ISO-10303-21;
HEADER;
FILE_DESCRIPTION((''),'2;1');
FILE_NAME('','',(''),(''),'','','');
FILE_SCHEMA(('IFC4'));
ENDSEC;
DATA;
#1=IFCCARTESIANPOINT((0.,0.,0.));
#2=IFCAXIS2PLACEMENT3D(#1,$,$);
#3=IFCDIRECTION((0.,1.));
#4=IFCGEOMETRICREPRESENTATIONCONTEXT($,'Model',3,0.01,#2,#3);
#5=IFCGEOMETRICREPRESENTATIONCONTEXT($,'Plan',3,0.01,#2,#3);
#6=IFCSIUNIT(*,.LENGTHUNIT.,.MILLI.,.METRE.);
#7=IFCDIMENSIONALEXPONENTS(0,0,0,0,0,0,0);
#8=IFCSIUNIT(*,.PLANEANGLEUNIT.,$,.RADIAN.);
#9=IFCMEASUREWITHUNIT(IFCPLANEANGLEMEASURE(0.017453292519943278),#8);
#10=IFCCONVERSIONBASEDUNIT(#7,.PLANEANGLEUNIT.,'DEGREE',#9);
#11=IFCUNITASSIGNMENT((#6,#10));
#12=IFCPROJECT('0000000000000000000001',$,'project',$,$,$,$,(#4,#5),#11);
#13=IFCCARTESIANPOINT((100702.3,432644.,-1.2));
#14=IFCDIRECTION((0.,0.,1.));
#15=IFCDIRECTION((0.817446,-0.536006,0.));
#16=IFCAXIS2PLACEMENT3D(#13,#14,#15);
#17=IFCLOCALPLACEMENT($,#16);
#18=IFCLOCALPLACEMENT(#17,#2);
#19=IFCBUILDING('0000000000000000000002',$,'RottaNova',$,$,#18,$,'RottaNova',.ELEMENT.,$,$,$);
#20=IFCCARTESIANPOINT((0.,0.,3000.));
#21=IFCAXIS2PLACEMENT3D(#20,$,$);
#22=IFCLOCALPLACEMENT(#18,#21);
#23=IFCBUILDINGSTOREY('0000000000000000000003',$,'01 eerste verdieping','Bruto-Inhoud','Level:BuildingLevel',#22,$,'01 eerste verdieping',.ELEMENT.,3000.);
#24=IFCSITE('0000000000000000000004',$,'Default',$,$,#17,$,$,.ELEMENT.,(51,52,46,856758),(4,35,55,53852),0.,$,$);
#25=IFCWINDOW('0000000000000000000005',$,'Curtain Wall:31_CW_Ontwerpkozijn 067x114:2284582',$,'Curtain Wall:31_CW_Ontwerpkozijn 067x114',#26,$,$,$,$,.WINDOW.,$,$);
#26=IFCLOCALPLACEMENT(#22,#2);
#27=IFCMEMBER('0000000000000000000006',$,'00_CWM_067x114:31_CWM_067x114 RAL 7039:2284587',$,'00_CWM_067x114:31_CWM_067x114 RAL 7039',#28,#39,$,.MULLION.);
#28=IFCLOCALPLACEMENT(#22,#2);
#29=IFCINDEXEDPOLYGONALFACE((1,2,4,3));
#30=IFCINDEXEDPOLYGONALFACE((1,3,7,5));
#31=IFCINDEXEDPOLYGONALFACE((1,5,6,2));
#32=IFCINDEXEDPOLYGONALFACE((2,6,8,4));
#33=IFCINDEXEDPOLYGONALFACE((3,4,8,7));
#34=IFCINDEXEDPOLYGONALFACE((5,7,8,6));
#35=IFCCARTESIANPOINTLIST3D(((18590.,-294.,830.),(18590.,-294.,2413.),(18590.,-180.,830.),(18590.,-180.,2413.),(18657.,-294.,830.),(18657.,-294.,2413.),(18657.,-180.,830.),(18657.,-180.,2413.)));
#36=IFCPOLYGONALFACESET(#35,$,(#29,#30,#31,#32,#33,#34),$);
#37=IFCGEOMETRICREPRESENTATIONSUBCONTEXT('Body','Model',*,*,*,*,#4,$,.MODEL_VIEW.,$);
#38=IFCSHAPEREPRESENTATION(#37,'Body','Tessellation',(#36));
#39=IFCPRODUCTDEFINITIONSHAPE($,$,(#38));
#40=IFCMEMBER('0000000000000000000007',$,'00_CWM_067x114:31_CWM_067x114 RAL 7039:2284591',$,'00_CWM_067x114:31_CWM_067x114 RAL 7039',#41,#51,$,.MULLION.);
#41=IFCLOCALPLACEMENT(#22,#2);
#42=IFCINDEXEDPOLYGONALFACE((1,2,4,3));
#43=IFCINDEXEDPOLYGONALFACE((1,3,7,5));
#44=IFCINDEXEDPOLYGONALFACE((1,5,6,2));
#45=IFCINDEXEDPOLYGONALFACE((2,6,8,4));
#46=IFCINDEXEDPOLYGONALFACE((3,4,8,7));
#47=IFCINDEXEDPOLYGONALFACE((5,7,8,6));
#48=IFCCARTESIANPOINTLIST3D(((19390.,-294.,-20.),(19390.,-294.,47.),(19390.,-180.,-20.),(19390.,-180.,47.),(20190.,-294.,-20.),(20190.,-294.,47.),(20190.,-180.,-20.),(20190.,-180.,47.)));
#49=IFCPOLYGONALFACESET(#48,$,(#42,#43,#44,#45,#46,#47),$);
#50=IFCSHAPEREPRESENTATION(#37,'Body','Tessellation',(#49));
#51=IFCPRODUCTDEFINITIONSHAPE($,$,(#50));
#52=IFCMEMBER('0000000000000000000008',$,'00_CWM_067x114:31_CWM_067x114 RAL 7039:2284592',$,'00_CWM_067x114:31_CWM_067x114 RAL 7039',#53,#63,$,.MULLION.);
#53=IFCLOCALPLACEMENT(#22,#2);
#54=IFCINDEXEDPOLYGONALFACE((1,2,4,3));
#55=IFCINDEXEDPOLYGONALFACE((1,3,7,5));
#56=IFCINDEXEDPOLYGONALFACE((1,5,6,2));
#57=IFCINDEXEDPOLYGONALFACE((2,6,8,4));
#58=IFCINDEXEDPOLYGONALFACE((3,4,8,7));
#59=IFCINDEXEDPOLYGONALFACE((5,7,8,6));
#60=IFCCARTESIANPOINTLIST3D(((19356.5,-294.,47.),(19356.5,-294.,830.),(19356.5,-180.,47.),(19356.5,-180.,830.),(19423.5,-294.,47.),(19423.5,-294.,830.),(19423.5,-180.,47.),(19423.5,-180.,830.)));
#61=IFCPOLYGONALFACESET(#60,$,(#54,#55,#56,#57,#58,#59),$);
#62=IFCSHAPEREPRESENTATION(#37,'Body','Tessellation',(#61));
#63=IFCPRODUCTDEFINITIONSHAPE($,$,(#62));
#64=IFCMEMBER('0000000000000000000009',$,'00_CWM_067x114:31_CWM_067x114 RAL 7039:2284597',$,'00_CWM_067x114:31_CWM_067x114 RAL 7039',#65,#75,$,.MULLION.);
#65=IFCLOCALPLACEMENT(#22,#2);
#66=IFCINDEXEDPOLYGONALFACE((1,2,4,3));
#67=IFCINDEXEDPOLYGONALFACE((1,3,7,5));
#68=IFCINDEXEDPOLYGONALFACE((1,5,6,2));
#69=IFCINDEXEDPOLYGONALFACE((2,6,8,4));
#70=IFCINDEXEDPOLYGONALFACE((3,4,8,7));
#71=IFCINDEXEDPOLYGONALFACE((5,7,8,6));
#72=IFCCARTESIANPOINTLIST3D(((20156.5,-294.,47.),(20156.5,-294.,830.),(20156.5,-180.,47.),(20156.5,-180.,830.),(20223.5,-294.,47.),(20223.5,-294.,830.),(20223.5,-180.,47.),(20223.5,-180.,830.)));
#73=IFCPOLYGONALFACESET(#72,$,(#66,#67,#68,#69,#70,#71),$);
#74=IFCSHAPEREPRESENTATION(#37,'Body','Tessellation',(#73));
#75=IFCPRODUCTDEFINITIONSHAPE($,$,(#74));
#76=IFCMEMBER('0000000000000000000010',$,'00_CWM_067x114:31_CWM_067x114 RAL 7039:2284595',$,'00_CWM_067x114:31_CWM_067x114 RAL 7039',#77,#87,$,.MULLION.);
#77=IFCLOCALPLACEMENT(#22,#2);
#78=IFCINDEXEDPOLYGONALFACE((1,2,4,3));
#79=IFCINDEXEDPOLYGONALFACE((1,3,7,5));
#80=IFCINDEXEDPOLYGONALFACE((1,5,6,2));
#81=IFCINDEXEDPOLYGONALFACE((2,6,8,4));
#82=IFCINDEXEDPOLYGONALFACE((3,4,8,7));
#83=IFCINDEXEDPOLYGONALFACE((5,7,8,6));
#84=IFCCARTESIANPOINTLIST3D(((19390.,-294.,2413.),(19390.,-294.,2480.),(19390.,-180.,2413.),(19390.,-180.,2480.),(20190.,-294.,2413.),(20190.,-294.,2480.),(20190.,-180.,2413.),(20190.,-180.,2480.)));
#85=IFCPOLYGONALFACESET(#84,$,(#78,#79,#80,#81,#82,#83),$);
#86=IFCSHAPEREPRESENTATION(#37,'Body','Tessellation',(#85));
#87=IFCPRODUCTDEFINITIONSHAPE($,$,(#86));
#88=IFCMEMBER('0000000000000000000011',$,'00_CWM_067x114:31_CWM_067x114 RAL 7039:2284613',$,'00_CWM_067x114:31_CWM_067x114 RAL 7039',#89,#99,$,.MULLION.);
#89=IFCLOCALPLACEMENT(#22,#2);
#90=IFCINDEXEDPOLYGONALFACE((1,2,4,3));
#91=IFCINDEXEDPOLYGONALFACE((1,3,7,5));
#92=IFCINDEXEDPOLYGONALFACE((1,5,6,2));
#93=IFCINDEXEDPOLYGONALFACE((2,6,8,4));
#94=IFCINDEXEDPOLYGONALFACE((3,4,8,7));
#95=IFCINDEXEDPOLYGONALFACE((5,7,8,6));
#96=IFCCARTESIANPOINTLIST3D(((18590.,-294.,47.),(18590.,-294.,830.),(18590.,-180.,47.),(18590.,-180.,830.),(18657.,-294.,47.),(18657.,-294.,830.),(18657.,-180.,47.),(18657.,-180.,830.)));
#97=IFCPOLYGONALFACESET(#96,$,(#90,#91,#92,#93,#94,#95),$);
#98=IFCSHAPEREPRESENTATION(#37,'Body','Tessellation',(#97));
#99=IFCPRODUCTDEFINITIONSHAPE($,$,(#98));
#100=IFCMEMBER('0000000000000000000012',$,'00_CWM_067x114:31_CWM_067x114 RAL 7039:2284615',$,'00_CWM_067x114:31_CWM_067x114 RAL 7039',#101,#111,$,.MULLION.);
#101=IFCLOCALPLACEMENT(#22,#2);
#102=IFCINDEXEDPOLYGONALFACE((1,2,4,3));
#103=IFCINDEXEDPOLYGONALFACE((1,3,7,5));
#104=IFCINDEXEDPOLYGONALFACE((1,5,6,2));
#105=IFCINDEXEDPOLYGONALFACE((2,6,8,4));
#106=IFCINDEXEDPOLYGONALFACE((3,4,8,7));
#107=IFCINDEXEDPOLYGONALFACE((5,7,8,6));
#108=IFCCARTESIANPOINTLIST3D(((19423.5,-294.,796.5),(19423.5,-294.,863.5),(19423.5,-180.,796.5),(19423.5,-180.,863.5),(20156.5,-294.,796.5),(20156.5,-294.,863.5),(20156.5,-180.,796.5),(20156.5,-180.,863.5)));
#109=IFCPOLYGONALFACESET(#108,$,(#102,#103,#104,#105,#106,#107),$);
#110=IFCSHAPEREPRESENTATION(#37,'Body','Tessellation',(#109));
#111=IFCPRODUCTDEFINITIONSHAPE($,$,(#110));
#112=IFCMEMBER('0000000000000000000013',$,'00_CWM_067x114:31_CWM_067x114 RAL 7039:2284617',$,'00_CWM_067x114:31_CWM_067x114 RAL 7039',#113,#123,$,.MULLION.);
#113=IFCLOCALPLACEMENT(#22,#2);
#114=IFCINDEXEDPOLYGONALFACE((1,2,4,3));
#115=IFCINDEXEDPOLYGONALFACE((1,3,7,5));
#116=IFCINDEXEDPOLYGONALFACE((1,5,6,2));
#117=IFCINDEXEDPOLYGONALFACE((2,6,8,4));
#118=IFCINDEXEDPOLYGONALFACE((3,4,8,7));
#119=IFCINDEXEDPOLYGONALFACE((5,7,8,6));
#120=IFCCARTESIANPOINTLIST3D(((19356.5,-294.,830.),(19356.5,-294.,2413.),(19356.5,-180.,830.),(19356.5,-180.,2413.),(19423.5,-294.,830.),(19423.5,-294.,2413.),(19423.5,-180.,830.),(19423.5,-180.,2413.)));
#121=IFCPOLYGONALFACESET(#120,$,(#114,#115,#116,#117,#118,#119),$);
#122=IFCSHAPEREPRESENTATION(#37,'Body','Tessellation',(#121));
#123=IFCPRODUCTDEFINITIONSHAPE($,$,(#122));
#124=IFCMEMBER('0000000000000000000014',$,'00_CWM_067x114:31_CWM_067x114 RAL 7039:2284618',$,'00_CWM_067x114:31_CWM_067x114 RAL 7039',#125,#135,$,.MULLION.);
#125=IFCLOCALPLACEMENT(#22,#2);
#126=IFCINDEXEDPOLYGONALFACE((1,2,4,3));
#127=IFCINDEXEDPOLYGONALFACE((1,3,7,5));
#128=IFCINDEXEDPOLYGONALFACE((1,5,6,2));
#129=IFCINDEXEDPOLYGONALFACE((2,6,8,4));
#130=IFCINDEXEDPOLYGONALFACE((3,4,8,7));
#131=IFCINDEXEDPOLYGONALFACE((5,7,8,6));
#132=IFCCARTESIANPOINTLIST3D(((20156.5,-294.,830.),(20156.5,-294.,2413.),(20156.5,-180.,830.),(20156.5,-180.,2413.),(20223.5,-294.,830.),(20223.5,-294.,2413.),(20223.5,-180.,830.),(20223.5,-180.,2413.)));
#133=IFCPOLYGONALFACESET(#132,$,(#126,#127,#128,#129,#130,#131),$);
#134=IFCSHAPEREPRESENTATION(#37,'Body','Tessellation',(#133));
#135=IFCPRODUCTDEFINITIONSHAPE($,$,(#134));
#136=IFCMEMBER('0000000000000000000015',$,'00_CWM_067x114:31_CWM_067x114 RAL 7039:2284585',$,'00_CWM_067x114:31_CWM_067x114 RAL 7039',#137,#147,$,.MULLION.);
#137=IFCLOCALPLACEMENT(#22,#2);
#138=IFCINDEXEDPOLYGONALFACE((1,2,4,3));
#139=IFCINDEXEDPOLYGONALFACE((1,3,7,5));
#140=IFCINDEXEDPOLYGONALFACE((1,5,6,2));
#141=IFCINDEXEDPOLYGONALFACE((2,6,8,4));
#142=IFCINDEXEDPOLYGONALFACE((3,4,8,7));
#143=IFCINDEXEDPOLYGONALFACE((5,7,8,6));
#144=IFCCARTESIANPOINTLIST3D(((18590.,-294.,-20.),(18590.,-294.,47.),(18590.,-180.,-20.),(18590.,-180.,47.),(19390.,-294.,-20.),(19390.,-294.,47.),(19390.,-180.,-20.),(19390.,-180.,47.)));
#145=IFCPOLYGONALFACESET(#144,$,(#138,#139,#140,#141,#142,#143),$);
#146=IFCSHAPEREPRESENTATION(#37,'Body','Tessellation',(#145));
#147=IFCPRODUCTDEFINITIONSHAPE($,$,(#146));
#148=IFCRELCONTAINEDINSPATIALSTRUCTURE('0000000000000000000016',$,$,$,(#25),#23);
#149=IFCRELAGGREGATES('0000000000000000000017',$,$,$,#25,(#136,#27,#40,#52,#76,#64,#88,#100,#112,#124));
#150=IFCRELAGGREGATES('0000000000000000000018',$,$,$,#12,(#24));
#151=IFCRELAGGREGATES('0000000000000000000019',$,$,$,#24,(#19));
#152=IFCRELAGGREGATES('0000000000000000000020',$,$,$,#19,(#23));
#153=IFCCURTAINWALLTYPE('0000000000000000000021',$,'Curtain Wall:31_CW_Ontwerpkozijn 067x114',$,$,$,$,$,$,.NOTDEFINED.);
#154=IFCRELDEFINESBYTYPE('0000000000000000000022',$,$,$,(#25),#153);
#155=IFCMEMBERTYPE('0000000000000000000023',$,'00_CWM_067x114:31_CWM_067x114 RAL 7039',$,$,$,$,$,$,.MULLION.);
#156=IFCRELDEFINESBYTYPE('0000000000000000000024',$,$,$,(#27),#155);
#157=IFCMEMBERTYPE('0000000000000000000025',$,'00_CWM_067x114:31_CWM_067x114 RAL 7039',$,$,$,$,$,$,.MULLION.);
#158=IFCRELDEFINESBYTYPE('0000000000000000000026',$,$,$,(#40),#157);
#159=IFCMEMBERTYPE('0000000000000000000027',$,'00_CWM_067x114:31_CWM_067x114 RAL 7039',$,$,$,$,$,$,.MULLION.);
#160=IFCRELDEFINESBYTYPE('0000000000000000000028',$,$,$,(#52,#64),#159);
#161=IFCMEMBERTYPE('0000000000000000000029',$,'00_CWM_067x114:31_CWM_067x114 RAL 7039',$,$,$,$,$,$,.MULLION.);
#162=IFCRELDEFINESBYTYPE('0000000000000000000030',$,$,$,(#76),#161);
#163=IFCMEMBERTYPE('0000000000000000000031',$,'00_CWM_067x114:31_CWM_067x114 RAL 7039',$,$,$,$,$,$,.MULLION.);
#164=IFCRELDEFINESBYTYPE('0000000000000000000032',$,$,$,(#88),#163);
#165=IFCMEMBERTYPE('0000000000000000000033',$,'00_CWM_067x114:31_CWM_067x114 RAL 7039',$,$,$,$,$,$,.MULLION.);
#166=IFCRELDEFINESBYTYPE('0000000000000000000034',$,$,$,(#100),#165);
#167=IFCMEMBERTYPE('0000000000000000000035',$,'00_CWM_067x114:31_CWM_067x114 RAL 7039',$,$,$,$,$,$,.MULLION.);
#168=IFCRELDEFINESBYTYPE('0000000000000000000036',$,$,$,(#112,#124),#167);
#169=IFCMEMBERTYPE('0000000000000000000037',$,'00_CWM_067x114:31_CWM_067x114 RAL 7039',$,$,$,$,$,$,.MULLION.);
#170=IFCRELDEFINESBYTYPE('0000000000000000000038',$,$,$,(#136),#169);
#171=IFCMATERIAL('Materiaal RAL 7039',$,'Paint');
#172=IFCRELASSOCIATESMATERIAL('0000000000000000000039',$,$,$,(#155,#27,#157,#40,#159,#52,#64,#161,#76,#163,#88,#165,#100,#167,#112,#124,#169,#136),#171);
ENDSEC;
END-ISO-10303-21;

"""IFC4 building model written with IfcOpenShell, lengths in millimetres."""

from ifc_helpers import new_model, entity, si_unit, converted_unit, direction, frame, origin, place, context, subcontext, project, spatial, indexed_curve, outline, extrude, source, transform, mapped, material, type_object, type_shapes, element, aggregate, save


model = new_model("IFC4")

# Units and contexts
model_context = context("Model", 3, precision=0.01, world=origin(), true_north=direction((0.0, 1.0)))
plan_context = context("Plan", 3, precision=0.01, world=origin(), true_north=direction((0.0, 1.0)))
body_context = subcontext(model_context, "Body", "Model", "MODEL_VIEW")
ifc_project = project(units=[si_unit("LENGTHUNIT", "METRE", prefix="MILLI"), converted_unit("PLANEANGLEUNIT", "DEGREE", entity("IfcPlaneAngleMeasure", 0.017453292519943278), si_unit("PLANEANGLEUNIT", "RADIAN"), dimensions=[0, 0, 0, 0, 0, 0, 0])], contexts=[model_context, plan_context])

# Site, building, storey
site_placement = place(None, frame((100702.3, 432644.0, -1.2), z_axis=(0.0, 0.0, 1.0), x_axis=(0.817446, -0.536006, 0.0)))
site = spatial("IfcSite", under=ifc_project, at=site_placement, Name="Default", CompositionType="ELEMENT", RefLatitude=(51, 52, 46, 856758), RefLongitude=(4, 35, 55, 53852), RefElevation=0.0)
building_placement = place(site_placement, origin())
building = spatial("IfcBuilding", under=site, at=building_placement, Name="RottaNova", LongName="RottaNova", CompositionType="ELEMENT")
storey_placement = place(building_placement, frame((0.0, 0.0, 3000.0)))
storey = spatial("IfcBuildingStorey", under=building, at=storey_placement, Name="01 eerste verdieping", Description="Bruto-Inhoud", ObjectType="Level:BuildingLevel", LongName="01 eerste verdieping", CompositionType="ELEMENT", Elevation=3000.0)

# Window, members
curtain_wall_type = type_object("IfcCurtainWallType", Name="Curtain Wall:31_CW_Ontwerpkozijn 067x114", PredefinedType="NOTDEFINED")
window_1_placement = place(storey_placement, frame((0.0, 0.0, -3000.0)))
window_1 = element("IfcWindow", 1, at=window_1_placement, inside=storey, type_object=curtain_wall_type, Name="Curtain Wall:31_CW_Ontwerpkozijn 067x114:2284582", ObjectType="Curtain Wall:31_CW_Ontwerpkozijn 067x114", PredefinedType="WINDOW")
ifc_material_1 = material(Name="Materiaal RAL 7039", Category="Paint")
member_type_1 = type_object("IfcMemberType", Name="00_CWM_067x114:31_CWM_067x114 RAL 7039", PredefinedType="MULLION", material=ifc_material_1)
shared_shape_1 = source(origin(), body_context, "Body", "SweptSolid", [
    extrude(outline(indexed_curve([(-33.5, -57.0), (33.5, -57.0), (33.5, 57.0), (-33.5, 57.0), (-33.5, -57.0)], self_intersect=False)), frame((-33.5, 57.0, -1583.0), z_axis=(0.0, 0.0, 1.0), x_axis=(-1.0, 0.0, 0.0)), (0.0, 0.0, 1.0), 1583.0),
])
type_shapes(member_type_1, [shared_shape_1])
member_1_placement = place(window_1_placement, frame((18590.0, -180.0, 5413.0), z_axis=(0.0, 0.0, 1.0), x_axis=(-1.0, 0.0, 0.0)))
member_1 = element("IfcMember", 2, at=member_1_placement, type_object=member_type_1, material=ifc_material_1, Name="00_CWM_067x114:31_CWM_067x114 RAL 7039:2284587", ObjectType="00_CWM_067x114:31_CWM_067x114 RAL 7039", PredefinedType="MULLION", context=body_context, shape_type="MappedRepresentation", body=[
    mapped(shared_shape_1, transform((0.0, 0.0, 0.0), scale=1.0)),
])
member_type_2 = type_object("IfcMemberType", Name="00_CWM_067x114:31_CWM_067x114 RAL 7039", PredefinedType="MULLION", material=ifc_material_1)
shared_shape_2 = source(origin(), body_context, "Body", "SweptSolid", [
    extrude(outline(indexed_curve([(-33.5, -57.0), (33.5, -57.0), (33.5, 57.0), (-33.5, 57.0), (-33.5, -57.0)], self_intersect=False)), frame((-33.5, 57.0, -800.0), z_axis=(0.0, 0.0, 1.0), x_axis=(-1.0, 0.0, 0.0)), (0.0, 0.0, 1.0), 800.0),
])
type_shapes(member_type_2, [shared_shape_2])
member_2_placement = place(window_1_placement, frame((19390.0, -180.0, 2980.0), z_axis=(-1.0, 0.0, 0.0), x_axis=(0.0, 0.0, -1.0)))
member_2 = element("IfcMember", 3, at=member_2_placement, type_object=member_type_2, material=ifc_material_1, Name="00_CWM_067x114:31_CWM_067x114 RAL 7039:2284591", ObjectType="00_CWM_067x114:31_CWM_067x114 RAL 7039", PredefinedType="MULLION", context=body_context, shape_type="MappedRepresentation", body=[
    mapped(shared_shape_2, transform((0.0, 0.0, 0.0), scale=1.0)),
])
member_type_3 = type_object("IfcMemberType", Name="00_CWM_067x114:31_CWM_067x114 RAL 7039", PredefinedType="MULLION", material=ifc_material_1)
shared_shape_3 = source(origin(), body_context, "Body", "SweptSolid", [
    extrude(outline(indexed_curve([(-33.5, -57.0), (33.5, -57.0), (33.5, 57.0), (-33.5, 57.0), (-33.5, -57.0)], self_intersect=False)), frame((0.0, 57.0, -783.0), z_axis=(0.0, 0.0, 1.0), x_axis=(-1.0, 0.0, 0.0)), (0.0, 0.0, 1.0), 783.0),
])
type_shapes(member_type_3, [shared_shape_3])
member_3_placement = place(window_1_placement, frame((19390.0, -180.0, 3047.0), z_axis=(0.0, 0.0, -1.0), x_axis=(1.0, 0.0, 0.0)))
member_3 = element("IfcMember", 4, at=member_3_placement, type_object=member_type_3, material=ifc_material_1, Name="00_CWM_067x114:31_CWM_067x114 RAL 7039:2284592", ObjectType="00_CWM_067x114:31_CWM_067x114 RAL 7039", PredefinedType="MULLION", context=body_context, shape_type="MappedRepresentation", body=[
    mapped(shared_shape_3, transform((0.0, 0.0, 0.0), scale=1.0)),
])
member_4_placement = place(window_1_placement, frame((20190.0, -180.0, 3047.0), z_axis=(0.0, 0.0, -1.0), x_axis=(1.0, 0.0, 0.0)))
member_4 = element("IfcMember", 5, at=member_4_placement, type_object=member_type_3, material=ifc_material_1, Name="00_CWM_067x114:31_CWM_067x114 RAL 7039:2284597", ObjectType="00_CWM_067x114:31_CWM_067x114 RAL 7039", PredefinedType="MULLION", context=body_context, shape_type="MappedRepresentation", body=[
    mapped(shared_shape_3, transform((0.0, 0.0, 0.0), scale=1.0)),
])
member_type_4 = type_object("IfcMemberType", Name="00_CWM_067x114:31_CWM_067x114 RAL 7039", PredefinedType="MULLION", material=ifc_material_1)
shared_shape_4 = source(origin(), body_context, "Body", "SweptSolid", [
    extrude(outline(indexed_curve([(-33.5, -57.0), (33.5, -57.0), (33.5, 57.0), (-33.5, 57.0), (-33.5, -57.0)], self_intersect=False)), frame((-33.5, 57.0, -800.0), z_axis=(0.0, 0.0, 1.0), x_axis=(-1.0, 0.0, 0.0)), (0.0, 0.0, 1.0), 800.0),
])
type_shapes(member_type_4, [shared_shape_4])
member_5_placement = place(window_1_placement, frame((20190.0, -180.0, 5480.0), z_axis=(1.0, 0.0, 0.0), x_axis=(0.0, 0.0, 1.0)))
member_5 = element("IfcMember", 6, at=member_5_placement, type_object=member_type_4, material=ifc_material_1, Name="00_CWM_067x114:31_CWM_067x114 RAL 7039:2284595", ObjectType="00_CWM_067x114:31_CWM_067x114 RAL 7039", PredefinedType="MULLION", context=body_context, shape_type="MappedRepresentation", body=[
    mapped(shared_shape_4, transform((0.0, 0.0, 0.0), scale=1.0)),
])
member_type_5 = type_object("IfcMemberType", Name="00_CWM_067x114:31_CWM_067x114 RAL 7039", PredefinedType="MULLION", material=ifc_material_1)
shared_shape_5 = source(origin(), body_context, "Body", "SweptSolid", [
    extrude(outline(indexed_curve([(-33.5, -57.0), (33.5, -57.0), (33.5, 57.0), (-33.5, 57.0), (-33.5, -57.0)], self_intersect=False)), frame((-33.5, 57.0, -783.0), z_axis=(0.0, 0.0, 1.0), x_axis=(-1.0, 0.0, 0.0)), (0.0, 0.0, 1.0), 783.0),
])
type_shapes(member_type_5, [shared_shape_5])
member_6_placement = place(window_1_placement, frame((18590.0, -180.0, 3830.0), z_axis=(0.0, 0.0, 1.0), x_axis=(-1.0, 0.0, 0.0)))
member_6 = element("IfcMember", 7, at=member_6_placement, type_object=member_type_5, material=ifc_material_1, Name="00_CWM_067x114:31_CWM_067x114 RAL 7039:2284613", ObjectType="00_CWM_067x114:31_CWM_067x114 RAL 7039", PredefinedType="MULLION", context=body_context, shape_type="MappedRepresentation", body=[
    mapped(shared_shape_5, transform((0.0, 0.0, 0.0), scale=1.0)),
])
member_type_6 = type_object("IfcMemberType", Name="00_CWM_067x114:31_CWM_067x114 RAL 7039", PredefinedType="MULLION", material=ifc_material_1)
shared_shape_6 = source(origin(), body_context, "Body", "SweptSolid", [
    extrude(outline(indexed_curve([(-33.5, -57.0), (33.5, -57.0), (33.5, 57.0), (-33.5, 57.0), (-33.5, -57.0)], self_intersect=False)), frame((0.0, 57.0, -733.0), z_axis=(0.0, 0.0, 1.0), x_axis=(-1.0, 0.0, 0.0)), (0.0, 0.0, 1.0), 733.0),
])
type_shapes(member_type_6, [shared_shape_6])
member_7_placement = place(window_1_placement, frame((20156.5, -180.0, 3830.0), z_axis=(1.0, 0.0, 0.0), x_axis=(0.0, 0.0, 1.0)))
member_7 = element("IfcMember", 8, at=member_7_placement, type_object=member_type_6, material=ifc_material_1, Name="00_CWM_067x114:31_CWM_067x114 RAL 7039:2284615", ObjectType="00_CWM_067x114:31_CWM_067x114 RAL 7039", PredefinedType="MULLION", context=body_context, shape_type="MappedRepresentation", body=[
    mapped(shared_shape_6, transform((0.0, 0.0, 0.0), scale=1.0)),
])
member_type_7 = type_object("IfcMemberType", Name="00_CWM_067x114:31_CWM_067x114 RAL 7039", PredefinedType="MULLION", material=ifc_material_1)
shared_shape_7 = source(origin(), body_context, "Body", "SweptSolid", [
    extrude(outline(indexed_curve([(-33.5, -57.0), (33.5, -57.0), (33.5, 57.0), (-33.5, 57.0), (-33.5, -57.0)], self_intersect=False)), frame((0.0, 57.0, -1583.0), z_axis=(0.0, 0.0, 1.0), x_axis=(-1.0, 0.0, 0.0)), (0.0, 0.0, 1.0), 1583.0),
])
type_shapes(member_type_7, [shared_shape_7])
member_8_placement = place(window_1_placement, frame((19390.0, -180.0, 3830.0), z_axis=(0.0, 0.0, -1.0), x_axis=(1.0, 0.0, 0.0)))
member_8 = element("IfcMember", 9, at=member_8_placement, type_object=member_type_7, material=ifc_material_1, Name="00_CWM_067x114:31_CWM_067x114 RAL 7039:2284617", ObjectType="00_CWM_067x114:31_CWM_067x114 RAL 7039", PredefinedType="MULLION", context=body_context, shape_type="MappedRepresentation", body=[
    mapped(shared_shape_7, transform((0.0, 0.0, 0.0), scale=1.0)),
])
member_9_placement = place(window_1_placement, frame((20190.0, -180.0, 3830.0), z_axis=(0.0, 0.0, -1.0), x_axis=(1.0, 0.0, 0.0)))
member_9 = element("IfcMember", 10, at=member_9_placement, type_object=member_type_7, material=ifc_material_1, Name="00_CWM_067x114:31_CWM_067x114 RAL 7039:2284618", ObjectType="00_CWM_067x114:31_CWM_067x114 RAL 7039", PredefinedType="MULLION", context=body_context, shape_type="MappedRepresentation", body=[
    mapped(shared_shape_7, transform((0.0, 0.0, 0.0), scale=1.0)),
])
member_type_8 = type_object("IfcMemberType", Name="00_CWM_067x114:31_CWM_067x114 RAL 7039", PredefinedType="MULLION", material=ifc_material_1)
shared_shape_8 = source(origin(), body_context, "Body", "SweptSolid", [
    extrude(outline(indexed_curve([(-33.5, -57.0), (33.5, -57.0), (33.5, 57.0), (-33.5, 57.0), (-33.5, -57.0)], self_intersect=False)), frame((-33.5, 57.0, -800.0), z_axis=(0.0, 0.0, 1.0), x_axis=(-1.0, 0.0, 0.0)), (0.0, 0.0, 1.0), 800.0),
])
type_shapes(member_type_8, [shared_shape_8])
member_10_placement = place(window_1_placement, frame((18590.0, -180.0, 2980.0), z_axis=(-1.0, 0.0, 0.0), x_axis=(0.0, 0.0, -1.0)))
member_10 = element("IfcMember", 11, at=member_10_placement, type_object=member_type_8, material=ifc_material_1, Name="00_CWM_067x114:31_CWM_067x114 RAL 7039:2284585", ObjectType="00_CWM_067x114:31_CWM_067x114 RAL 7039", PredefinedType="MULLION", context=body_context, shape_type="MappedRepresentation", body=[
    mapped(shared_shape_8, transform((0.0, 0.0, 0.0), scale=1.0)),
])
aggregate(window_1, [member_10, member_1, member_2, member_3, member_5, member_4, member_6, member_7, member_8, member_9])

save(model, "model.ifc")
